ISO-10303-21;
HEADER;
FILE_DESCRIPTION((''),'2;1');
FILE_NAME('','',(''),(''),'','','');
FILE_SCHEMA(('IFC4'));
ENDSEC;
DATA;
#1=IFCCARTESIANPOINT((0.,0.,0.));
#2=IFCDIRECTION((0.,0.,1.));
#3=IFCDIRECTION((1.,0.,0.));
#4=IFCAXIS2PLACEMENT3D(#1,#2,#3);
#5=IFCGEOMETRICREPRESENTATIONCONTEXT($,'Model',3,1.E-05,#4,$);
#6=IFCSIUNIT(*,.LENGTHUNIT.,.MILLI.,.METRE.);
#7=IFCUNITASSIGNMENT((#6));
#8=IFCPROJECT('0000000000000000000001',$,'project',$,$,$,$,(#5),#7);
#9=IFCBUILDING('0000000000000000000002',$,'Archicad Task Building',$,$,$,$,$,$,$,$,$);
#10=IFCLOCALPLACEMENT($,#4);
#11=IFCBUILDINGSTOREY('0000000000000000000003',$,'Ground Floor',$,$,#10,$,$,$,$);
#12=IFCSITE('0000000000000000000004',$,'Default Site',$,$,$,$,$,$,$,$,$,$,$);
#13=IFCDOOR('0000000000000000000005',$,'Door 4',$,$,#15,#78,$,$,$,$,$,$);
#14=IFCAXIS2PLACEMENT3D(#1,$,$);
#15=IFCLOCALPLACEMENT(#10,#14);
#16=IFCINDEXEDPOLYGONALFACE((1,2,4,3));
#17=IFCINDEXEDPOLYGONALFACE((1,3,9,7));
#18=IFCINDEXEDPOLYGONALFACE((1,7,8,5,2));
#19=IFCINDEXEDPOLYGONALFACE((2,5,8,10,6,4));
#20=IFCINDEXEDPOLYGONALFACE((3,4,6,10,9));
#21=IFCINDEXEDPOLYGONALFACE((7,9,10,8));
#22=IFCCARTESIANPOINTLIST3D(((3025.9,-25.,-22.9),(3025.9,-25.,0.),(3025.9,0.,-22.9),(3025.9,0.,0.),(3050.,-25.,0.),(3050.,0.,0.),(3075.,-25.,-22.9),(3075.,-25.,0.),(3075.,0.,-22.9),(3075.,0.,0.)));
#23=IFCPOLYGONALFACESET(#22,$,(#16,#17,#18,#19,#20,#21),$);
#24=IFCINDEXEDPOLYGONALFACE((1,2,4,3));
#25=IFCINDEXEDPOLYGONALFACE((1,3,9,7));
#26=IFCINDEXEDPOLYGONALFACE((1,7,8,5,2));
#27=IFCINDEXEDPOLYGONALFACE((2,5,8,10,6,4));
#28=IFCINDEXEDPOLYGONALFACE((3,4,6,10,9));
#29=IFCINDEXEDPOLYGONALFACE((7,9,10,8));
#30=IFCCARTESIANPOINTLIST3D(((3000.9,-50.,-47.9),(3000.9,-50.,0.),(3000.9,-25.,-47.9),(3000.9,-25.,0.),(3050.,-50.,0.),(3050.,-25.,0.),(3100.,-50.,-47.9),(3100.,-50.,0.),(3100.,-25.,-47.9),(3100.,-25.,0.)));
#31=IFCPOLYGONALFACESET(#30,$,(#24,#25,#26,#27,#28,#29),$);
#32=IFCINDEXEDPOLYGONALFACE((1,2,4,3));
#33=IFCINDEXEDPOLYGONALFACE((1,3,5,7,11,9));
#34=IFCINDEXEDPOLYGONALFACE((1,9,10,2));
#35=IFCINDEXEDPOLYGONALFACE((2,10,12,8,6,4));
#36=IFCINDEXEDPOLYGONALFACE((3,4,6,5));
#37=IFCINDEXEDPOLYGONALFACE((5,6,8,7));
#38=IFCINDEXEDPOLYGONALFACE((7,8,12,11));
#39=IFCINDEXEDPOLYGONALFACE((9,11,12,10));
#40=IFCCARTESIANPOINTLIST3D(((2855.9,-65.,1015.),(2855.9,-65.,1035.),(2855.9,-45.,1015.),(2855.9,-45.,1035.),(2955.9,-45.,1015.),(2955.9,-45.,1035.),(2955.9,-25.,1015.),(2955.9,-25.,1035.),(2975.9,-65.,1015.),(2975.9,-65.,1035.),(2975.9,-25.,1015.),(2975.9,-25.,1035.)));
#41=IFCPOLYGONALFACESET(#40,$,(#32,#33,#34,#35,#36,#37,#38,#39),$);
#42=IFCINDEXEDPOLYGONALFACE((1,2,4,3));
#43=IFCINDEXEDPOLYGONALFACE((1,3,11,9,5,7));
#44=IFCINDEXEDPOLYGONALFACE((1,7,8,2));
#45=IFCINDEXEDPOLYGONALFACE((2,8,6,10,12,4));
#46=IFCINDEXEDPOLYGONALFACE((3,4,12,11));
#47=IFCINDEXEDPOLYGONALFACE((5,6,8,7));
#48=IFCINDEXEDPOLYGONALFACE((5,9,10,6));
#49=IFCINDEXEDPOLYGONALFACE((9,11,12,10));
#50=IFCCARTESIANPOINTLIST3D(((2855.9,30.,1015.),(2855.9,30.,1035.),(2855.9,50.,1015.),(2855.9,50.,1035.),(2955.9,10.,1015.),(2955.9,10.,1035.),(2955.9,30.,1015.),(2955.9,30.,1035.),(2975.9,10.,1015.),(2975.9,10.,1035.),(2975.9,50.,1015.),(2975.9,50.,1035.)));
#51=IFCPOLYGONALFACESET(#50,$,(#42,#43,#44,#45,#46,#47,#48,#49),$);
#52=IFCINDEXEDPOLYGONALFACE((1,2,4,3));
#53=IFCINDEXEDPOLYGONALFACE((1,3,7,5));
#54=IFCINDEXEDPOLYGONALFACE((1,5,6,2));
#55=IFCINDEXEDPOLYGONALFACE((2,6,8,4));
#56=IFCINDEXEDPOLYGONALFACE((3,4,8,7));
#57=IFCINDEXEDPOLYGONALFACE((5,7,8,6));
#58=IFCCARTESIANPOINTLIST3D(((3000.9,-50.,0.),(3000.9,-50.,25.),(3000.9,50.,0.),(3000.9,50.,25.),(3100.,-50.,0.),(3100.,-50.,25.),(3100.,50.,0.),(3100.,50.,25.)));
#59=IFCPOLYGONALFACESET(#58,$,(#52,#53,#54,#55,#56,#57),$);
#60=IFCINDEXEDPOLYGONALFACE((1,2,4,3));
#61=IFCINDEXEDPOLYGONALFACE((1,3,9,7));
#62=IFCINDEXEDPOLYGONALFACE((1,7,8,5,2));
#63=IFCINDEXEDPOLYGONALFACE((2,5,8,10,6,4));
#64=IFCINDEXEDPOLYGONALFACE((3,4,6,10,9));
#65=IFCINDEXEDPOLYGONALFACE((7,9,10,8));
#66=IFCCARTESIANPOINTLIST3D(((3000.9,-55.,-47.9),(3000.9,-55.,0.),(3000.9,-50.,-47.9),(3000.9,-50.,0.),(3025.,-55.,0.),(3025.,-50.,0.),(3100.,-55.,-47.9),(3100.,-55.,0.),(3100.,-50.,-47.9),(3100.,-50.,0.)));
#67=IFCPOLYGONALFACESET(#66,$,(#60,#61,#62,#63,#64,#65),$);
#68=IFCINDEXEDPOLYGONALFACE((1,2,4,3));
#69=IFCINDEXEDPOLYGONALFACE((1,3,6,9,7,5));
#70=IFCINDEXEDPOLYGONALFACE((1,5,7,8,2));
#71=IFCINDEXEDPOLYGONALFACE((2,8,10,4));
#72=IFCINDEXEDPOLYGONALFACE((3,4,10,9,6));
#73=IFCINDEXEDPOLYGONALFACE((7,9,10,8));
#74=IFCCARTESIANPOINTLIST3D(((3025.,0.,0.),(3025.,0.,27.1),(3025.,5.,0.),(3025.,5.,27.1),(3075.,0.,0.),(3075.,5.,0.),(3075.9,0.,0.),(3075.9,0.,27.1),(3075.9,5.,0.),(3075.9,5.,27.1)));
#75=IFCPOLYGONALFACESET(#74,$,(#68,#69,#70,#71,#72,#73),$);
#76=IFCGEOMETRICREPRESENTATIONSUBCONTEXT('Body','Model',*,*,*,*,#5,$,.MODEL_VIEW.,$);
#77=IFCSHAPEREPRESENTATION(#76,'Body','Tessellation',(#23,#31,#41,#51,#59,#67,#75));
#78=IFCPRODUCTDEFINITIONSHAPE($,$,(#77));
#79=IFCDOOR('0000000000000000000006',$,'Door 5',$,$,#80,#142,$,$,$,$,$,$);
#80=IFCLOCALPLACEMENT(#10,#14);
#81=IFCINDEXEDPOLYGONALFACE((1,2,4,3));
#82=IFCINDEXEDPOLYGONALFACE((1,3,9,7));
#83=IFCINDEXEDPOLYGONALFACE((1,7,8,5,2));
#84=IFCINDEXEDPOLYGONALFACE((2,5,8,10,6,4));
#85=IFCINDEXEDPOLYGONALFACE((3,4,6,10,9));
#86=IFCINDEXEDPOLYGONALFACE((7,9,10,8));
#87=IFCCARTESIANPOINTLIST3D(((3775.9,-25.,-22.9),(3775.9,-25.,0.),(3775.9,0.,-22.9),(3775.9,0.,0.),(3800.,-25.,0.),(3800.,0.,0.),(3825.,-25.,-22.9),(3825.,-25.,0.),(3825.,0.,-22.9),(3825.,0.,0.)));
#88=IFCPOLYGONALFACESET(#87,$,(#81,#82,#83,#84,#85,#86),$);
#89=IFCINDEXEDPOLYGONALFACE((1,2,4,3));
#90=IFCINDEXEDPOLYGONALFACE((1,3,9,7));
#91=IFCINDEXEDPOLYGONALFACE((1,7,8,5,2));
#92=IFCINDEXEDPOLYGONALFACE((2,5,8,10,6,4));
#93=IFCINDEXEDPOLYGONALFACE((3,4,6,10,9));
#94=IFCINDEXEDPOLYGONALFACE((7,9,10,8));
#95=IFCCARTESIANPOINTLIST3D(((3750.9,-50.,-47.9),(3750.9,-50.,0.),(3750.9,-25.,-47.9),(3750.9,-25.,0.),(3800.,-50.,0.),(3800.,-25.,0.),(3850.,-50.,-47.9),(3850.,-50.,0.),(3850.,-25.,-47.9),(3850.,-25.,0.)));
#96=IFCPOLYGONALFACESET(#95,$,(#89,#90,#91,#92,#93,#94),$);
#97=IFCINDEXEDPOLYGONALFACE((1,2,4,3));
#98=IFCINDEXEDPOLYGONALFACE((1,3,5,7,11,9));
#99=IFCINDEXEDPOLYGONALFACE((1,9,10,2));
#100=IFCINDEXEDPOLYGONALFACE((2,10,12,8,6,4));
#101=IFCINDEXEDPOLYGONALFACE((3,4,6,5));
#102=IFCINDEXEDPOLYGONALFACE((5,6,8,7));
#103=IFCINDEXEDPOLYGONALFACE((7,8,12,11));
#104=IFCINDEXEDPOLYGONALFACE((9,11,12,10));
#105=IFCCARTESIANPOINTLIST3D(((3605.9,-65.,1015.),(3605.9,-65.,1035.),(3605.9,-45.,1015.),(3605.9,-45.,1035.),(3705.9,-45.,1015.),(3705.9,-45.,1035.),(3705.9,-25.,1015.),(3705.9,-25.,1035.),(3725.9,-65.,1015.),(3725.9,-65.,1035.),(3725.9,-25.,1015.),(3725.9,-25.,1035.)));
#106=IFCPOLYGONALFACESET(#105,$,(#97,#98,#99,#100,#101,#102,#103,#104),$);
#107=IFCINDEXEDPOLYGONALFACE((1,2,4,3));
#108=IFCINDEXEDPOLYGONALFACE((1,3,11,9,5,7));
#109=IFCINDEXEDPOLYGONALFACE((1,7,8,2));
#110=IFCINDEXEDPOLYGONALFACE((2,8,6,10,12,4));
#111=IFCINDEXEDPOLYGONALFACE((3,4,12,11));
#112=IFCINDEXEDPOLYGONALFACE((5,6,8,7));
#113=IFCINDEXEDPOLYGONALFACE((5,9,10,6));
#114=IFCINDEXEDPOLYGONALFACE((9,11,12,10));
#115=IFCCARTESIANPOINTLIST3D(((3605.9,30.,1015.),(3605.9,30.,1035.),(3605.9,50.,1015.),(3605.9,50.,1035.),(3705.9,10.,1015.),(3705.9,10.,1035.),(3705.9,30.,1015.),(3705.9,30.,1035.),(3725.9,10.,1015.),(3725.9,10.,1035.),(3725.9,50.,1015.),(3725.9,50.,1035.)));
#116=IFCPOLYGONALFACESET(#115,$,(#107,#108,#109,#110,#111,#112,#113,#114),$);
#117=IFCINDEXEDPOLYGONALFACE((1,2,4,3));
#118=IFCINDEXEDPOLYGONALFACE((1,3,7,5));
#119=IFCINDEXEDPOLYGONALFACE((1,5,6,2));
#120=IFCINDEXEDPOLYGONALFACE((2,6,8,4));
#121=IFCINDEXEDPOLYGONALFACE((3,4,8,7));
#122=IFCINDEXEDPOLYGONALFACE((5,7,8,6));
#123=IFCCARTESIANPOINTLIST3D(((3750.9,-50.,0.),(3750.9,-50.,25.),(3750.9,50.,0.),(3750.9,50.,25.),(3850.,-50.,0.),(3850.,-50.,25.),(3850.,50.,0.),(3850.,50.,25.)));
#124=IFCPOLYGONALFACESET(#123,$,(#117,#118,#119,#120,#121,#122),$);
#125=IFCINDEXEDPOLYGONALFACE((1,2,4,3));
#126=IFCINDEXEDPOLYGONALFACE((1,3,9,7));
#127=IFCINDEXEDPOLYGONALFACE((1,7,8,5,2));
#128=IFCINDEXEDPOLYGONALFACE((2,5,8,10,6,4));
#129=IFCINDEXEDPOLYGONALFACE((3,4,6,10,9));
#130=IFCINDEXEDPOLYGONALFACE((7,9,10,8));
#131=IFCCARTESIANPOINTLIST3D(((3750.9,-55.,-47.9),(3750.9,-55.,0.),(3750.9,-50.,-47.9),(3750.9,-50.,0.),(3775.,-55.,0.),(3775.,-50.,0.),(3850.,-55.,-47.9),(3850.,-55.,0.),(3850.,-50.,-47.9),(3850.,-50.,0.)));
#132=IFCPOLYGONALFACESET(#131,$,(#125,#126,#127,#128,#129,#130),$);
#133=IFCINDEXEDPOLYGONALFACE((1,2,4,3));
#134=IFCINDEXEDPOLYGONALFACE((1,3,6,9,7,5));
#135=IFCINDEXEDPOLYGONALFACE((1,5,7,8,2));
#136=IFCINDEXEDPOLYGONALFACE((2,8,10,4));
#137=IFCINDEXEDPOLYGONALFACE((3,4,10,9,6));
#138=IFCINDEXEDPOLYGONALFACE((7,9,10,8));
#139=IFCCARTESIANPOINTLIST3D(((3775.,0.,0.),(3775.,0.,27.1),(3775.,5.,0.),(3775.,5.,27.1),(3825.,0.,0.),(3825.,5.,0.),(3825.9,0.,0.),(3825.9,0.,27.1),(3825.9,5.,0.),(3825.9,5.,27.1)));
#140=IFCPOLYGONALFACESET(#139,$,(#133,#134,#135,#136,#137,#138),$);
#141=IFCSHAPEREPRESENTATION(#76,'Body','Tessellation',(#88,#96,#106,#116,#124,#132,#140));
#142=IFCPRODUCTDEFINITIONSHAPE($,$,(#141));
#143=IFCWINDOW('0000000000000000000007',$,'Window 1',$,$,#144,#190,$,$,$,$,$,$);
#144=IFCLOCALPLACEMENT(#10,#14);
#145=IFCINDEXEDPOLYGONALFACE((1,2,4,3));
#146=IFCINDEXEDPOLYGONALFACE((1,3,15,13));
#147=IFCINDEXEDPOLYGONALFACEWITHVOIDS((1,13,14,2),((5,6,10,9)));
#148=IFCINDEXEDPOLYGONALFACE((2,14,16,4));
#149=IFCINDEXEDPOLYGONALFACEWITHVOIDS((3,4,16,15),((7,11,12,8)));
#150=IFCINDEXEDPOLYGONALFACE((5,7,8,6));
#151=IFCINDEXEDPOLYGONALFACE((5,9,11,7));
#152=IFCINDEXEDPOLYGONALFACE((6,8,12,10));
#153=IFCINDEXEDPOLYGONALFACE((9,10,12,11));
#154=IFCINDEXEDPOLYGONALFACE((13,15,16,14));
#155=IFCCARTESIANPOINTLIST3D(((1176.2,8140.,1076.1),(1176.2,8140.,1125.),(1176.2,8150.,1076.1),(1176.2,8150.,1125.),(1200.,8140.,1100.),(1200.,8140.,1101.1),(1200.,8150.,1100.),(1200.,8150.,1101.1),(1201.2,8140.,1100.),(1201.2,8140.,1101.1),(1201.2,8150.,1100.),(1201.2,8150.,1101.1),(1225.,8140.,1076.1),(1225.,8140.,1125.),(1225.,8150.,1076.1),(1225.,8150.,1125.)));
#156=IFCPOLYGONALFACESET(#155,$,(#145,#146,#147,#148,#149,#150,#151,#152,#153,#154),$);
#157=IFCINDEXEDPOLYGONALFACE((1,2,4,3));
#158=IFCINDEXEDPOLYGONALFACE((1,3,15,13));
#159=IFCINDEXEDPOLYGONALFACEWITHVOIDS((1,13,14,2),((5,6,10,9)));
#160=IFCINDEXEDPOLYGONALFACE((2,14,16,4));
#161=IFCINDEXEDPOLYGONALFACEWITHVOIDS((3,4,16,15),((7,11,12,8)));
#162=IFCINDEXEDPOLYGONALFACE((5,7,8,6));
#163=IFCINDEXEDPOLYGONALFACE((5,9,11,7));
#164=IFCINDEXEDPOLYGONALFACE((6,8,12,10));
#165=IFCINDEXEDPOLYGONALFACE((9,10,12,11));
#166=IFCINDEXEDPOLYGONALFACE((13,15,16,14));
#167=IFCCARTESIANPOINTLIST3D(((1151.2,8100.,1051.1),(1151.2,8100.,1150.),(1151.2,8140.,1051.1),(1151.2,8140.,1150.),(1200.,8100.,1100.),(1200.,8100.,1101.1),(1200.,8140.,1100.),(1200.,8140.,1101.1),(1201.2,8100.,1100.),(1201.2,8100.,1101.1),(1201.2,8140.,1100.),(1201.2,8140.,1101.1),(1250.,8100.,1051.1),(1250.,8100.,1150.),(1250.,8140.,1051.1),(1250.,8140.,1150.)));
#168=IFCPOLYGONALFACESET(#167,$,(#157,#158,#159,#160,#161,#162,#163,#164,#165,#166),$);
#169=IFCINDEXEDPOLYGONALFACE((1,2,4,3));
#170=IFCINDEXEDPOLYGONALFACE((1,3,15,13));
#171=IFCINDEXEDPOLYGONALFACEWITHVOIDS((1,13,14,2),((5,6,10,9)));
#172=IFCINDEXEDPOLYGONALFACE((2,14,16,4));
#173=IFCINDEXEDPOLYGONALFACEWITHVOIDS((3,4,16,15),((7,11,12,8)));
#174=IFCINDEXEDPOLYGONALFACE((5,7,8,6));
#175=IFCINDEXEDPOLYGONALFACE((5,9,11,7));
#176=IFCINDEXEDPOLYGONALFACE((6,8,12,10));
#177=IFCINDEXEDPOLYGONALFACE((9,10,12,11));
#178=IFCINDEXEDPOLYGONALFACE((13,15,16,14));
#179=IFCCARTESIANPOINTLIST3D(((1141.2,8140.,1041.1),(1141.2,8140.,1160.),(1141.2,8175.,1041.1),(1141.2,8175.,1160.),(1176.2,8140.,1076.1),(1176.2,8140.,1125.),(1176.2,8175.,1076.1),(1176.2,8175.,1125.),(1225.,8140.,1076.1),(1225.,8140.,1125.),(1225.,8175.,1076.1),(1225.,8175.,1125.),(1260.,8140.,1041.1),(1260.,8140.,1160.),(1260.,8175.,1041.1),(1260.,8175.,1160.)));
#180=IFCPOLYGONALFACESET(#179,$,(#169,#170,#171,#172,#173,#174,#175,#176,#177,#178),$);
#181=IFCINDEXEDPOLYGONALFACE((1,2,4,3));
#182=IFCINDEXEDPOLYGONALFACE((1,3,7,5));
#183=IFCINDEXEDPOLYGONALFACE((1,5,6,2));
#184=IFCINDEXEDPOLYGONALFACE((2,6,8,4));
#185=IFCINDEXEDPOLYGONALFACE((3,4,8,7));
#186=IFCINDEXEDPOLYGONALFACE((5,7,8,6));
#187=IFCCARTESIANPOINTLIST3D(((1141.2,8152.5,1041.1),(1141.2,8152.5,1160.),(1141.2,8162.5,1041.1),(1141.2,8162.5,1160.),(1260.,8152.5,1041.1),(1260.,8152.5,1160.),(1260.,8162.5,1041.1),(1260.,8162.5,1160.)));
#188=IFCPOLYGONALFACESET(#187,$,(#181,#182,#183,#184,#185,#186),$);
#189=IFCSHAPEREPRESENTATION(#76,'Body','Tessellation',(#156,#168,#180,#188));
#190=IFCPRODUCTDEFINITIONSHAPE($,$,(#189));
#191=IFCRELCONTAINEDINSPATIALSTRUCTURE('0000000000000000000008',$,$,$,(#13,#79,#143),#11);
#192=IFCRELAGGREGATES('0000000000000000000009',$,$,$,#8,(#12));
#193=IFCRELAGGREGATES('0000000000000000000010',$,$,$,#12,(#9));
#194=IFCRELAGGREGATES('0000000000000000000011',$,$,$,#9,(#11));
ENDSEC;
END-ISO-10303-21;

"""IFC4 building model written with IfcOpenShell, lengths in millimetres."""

from ifc_helpers import new_model, si_unit, frame, origin_with_axes, place, context, subcontext, project, spatial, line, indexed_curve, outline, extrude, element, save


model = new_model("IFC4")

# Units and contexts
model_context = context("Model", 3, precision=1e-05, world=origin_with_axes())
body_context = subcontext(model_context, "Body", "Model", "MODEL_VIEW")
ifc_project = project(units=[si_unit("LENGTHUNIT", "METRE", prefix="MILLI")], contexts=[model_context])

# Site, building, storey
site = spatial("IfcSite", under=ifc_project, Name="Default Site")
building = spatial("IfcBuilding", under=site, Name="Archicad Task Building")
storey_placement = place(None, origin_with_axes())
storey = spatial("IfcBuildingStorey", under=building, at=storey_placement, Name="Ground Floor")

# Doors
door_1_placement = place(storey_placement, frame((3050.0, -50.0, 0.0), z_axis=(0.0, 0.0, 1.0), x_axis=(1.0, 0.0, 0.0)))
element("IfcDoor", 1, at=door_1_placement, inside=storey, Name="Door 4", context=body_context, shape_type="SweptSolid", body=[
    extrude(outline(indexed_curve([(0.0, 0.0), (0.0, 2.1), (0.9, 2.1), (0.9, 0.0), (-24.1, 0.0), (-24.1, -22.9), (25.0, -22.9), (25.0, 0.0)], segments=[line(1, 2, 3, 4, 5, 6, 7, 8, 1)])), frame((0.0, 25.0, 0.0), z_axis=(0.0, -1.0, 0.0), x_axis=(1.0, 0.0, 0.0)), (0.0, 0.0, -1.0), 25.0),
    extrude(outline(indexed_curve([(0.0, 0.0), (0.0, 2.1), (0.9, 2.1), (0.9, 0.0), (-49.1, 0.0), (-49.1, -47.9), (50.0, -47.9), (50.0, 0.0)], segments=[line(1, 2, 3, 4, 5, 6, 7, 8, 1)])), frame((0.0, 0.0, 0.0), z_axis=(0.0, -1.0, 0.0), x_axis=(1.0, 0.0, 0.0)), (0.0, 0.0, -1.0), 25.0),
    extrude(outline(indexed_curve([(0.0, 0.0), (-49.1, 0.0), (-49.1, 35.0), (0.0, 35.0)], segments=[line(1, 2, 3, 4, 1)])), frame((25.0, 25.0, 25.0), z_axis=(0.0, 0.0, 1.0), x_axis=(1.0, 0.0, 0.0)), (0.0, 0.0, 1.0), -47.9),
    extrude(outline(indexed_curve([(0.0, 0.0), (0.0, -40.0), (-120.0, -40.0), (-120.0, -20.0), (-20.0, -20.0), (-20.0, 0.0)], segments=[line(1, 2, 3, 4, 5, 6, 1)])), frame((-74.1, 25.0, 1015.0), z_axis=(0.0, 0.0, 1.0), x_axis=(1.0, 0.0, 0.0)), (0.0, 0.0, 1.0), 20.0),
    extrude(outline(indexed_curve([(0.0, 0.0), (0.0, 40.0), (-120.0, 40.0), (-120.0, 20.0), (-20.0, 20.0), (-20.0, 0.0)], segments=[line(1, 2, 3, 4, 5, 6, 1)])), frame((-74.1, 60.0, 1015.0), z_axis=(0.0, 0.0, 1.0), x_axis=(1.0, 0.0, 0.0)), (0.0, 0.0, 1.0), 20.0),
    extrude(outline(indexed_curve([(0.0, 0.0), (-99.1, 0.0), (-99.1, 100.0), (0.0, 100.0)], segments=[line(1, 2, 3, 4, 1)])), frame((50.0, 0.0, 0.0), z_axis=(0.0, 0.0, 1.0), x_axis=(1.0, 0.0, 0.0)), (0.0, 0.0, 1.0), 25.0),
    extrude(outline(indexed_curve([(0.0, 0.0), (0.0, 27.1), (50.9, 27.1), (50.9, 0.0), (-24.1, 0.0), (-24.1, -47.9), (75.0, -47.9), (75.0, 0.0)], segments=[line(1, 2, 3, 4, 5, 6, 7, 8, 1)])), frame((-25.0, -5.0, 0.0), z_axis=(0.0, -1.0, 0.0), x_axis=(1.0, 0.0, 0.0)), (0.0, 0.0, -1.0), 5.0),
    extrude(outline(indexed_curve([(0.0, 0.0), (0.0, 27.1), (50.9, 27.1), (50.9, 0.0), (0.9, 0.0), (0.9, -22.9), (50.0, -22.9), (50.0, 0.0)], segments=[line(1, 2, 3, 4, 5, 6, 7, 8, 1)])), frame((-25.0, 50.0, 0.0), z_axis=(0.0, -1.0, 0.0), x_axis=(1.0, 0.0, 0.0)), (0.0, 0.0, -1.0), 5.0),
])
door_2_placement = place(storey_placement, frame((3800.0, -50.0, 0.0), z_axis=(0.0, 0.0, 1.0), x_axis=(1.0, 0.0, 0.0)))
element("IfcDoor", 2, at=door_2_placement, inside=storey, Name="Door 5", context=body_context, shape_type="SweptSolid", body=[
    extrude(outline(indexed_curve([(0.0, 0.0), (0.0, 2.1), (0.9, 2.1), (0.9, 0.0), (-24.1, 0.0), (-24.1, -22.9), (25.0, -22.9), (25.0, 0.0)], segments=[line(1, 2, 3, 4, 5, 6, 7, 8, 1)])), frame((0.0, 25.0, 0.0), z_axis=(0.0, -1.0, 0.0), x_axis=(1.0, 0.0, 0.0)), (0.0, 0.0, -1.0), 25.0),
    extrude(outline(indexed_curve([(0.0, 0.0), (0.0, 2.1), (0.9, 2.1), (0.9, 0.0), (-49.1, 0.0), (-49.1, -47.9), (50.0, -47.9), (50.0, 0.0)], segments=[line(1, 2, 3, 4, 5, 6, 7, 8, 1)])), frame((0.0, 0.0, 0.0), z_axis=(0.0, -1.0, 0.0), x_axis=(1.0, 0.0, 0.0)), (0.0, 0.0, -1.0), 25.0),
    extrude(outline(indexed_curve([(0.0, 0.0), (-49.1, 0.0), (-49.1, 35.0), (0.0, 35.0)], segments=[line(1, 2, 3, 4, 1)])), frame((25.0, 25.0, 25.0), z_axis=(0.0, 0.0, 1.0), x_axis=(1.0, 0.0, 0.0)), (0.0, 0.0, 1.0), -47.9),
    extrude(outline(indexed_curve([(0.0, 0.0), (0.0, -40.0), (-120.0, -40.0), (-120.0, -20.0), (-20.0, -20.0), (-20.0, 0.0)], segments=[line(1, 2, 3, 4, 5, 6, 1)])), frame((-74.1, 25.0, 1015.0), z_axis=(0.0, 0.0, 1.0), x_axis=(1.0, 0.0, 0.0)), (0.0, 0.0, 1.0), 20.0),
    extrude(outline(indexed_curve([(0.0, 0.0), (0.0, 40.0), (-120.0, 40.0), (-120.0, 20.0), (-20.0, 20.0), (-20.0, 0.0)], segments=[line(1, 2, 3, 4, 5, 6, 1)])), frame((-74.1, 60.0, 1015.0), z_axis=(0.0, 0.0, 1.0), x_axis=(1.0, 0.0, 0.0)), (0.0, 0.0, 1.0), 20.0),
    extrude(outline(indexed_curve([(0.0, 0.0), (-99.1, 0.0), (-99.1, 100.0), (0.0, 100.0)], segments=[line(1, 2, 3, 4, 1)])), frame((50.0, 0.0, 0.0), z_axis=(0.0, 0.0, 1.0), x_axis=(1.0, 0.0, 0.0)), (0.0, 0.0, 1.0), 25.0),
    extrude(outline(indexed_curve([(0.0, 0.0), (0.0, 27.1), (50.9, 27.1), (50.9, 0.0), (-24.1, 0.0), (-24.1, -47.9), (75.0, -47.9), (75.0, 0.0)], segments=[line(1, 2, 3, 4, 5, 6, 7, 8, 1)])), frame((-25.0, -5.0, 0.0), z_axis=(0.0, -1.0, 0.0), x_axis=(1.0, 0.0, 0.0)), (0.0, 0.0, -1.0), 5.0),
    extrude(outline(indexed_curve([(0.0, 0.0), (0.0, 27.1), (50.9, 27.1), (50.9, 0.0), (0.9, 0.0), (0.9, -22.9), (50.0, -22.9), (50.0, 0.0)], segments=[line(1, 2, 3, 4, 5, 6, 7, 8, 1)])), frame((-25.0, 50.0, 0.0), z_axis=(0.0, -1.0, 0.0), x_axis=(1.0, 0.0, 0.0)), (0.0, 0.0, -1.0), 5.0),
])

# Window
for number, where, z_axis, x_axis, name in (
    (3, (1200.0, 8050.0, 1100.0), (0.0, 0.0, 1.0), (1.0, 0.0, 0.0), "Window 1"),
):
    element("IfcWindow", number, at=place(storey_placement, frame(where, z_axis=z_axis, x_axis=x_axis)), inside=storey, Name=name, context=body_context, shape_type="SweptSolid", body=[
        extrude(outline(indexed_curve([(0.0, 0.0), (1.2, 0.0), (1.2, 1.1), (0.0, 1.1)], segments=[line(1, 2, 3, 4, 1)]), holes=[indexed_curve([(25.0, 25.0), (-23.8, 25.0), (-23.8, -23.9), (25.0, -23.9)], segments=[line(1, 2, 3, 4, 1)])]), frame((0.0, 90.0, 0.0), z_axis=(0.0, -1.0, 0.0), x_axis=(1.0, 0.0, 0.0)), (0.0, 0.0, -1.0), 10.0),
        extrude(outline(indexed_curve([(0.0, 0.0), (1.2, 0.0), (1.2, 1.1), (0.0, 1.1)], segments=[line(1, 2, 3, 4, 1)]), holes=[indexed_curve([(50.0, 50.0), (-48.8, 50.0), (-48.8, -48.9), (50.0, -48.9)], segments=[line(1, 2, 3, 4, 1)])]), frame((0.0, 50.0, 0.0), z_axis=(0.0, -1.0, 0.0), x_axis=(1.0, 0.0, 0.0)), (0.0, 0.0, -1.0), 40.0),
        extrude(outline(indexed_curve([(0.0, 0.0), (-48.8, 0.0), (-48.8, -48.9), (0.0, -48.9)], segments=[line(1, 2, 3, 4, 1)]), holes=[indexed_curve([(35.0, 35.0), (-83.8, 35.0), (-83.8, -83.9), (35.0, -83.9)], segments=[line(1, 2, 3, 4, 1)])]), frame((25.0, 90.0, 25.0), z_axis=(0.0, -1.0, 0.0), x_axis=(1.0, 0.0, 0.0)), (0.0, 0.0, -1.0), 35.0),
        extrude(outline(indexed_curve([(35.0, 35.0), (-83.8, 35.0), (-83.8, -83.9), (35.0, -83.9)], segments=[line(1, 2, 3, 4, 1)])), frame((25.0, 102.5, 25.0), z_axis=(0.0, -1.0, 0.0), x_axis=(1.0, 0.0, 0.0)), (0.0, 0.0, -1.0), 10.0),
    ])

save(model, "model.ifc")
